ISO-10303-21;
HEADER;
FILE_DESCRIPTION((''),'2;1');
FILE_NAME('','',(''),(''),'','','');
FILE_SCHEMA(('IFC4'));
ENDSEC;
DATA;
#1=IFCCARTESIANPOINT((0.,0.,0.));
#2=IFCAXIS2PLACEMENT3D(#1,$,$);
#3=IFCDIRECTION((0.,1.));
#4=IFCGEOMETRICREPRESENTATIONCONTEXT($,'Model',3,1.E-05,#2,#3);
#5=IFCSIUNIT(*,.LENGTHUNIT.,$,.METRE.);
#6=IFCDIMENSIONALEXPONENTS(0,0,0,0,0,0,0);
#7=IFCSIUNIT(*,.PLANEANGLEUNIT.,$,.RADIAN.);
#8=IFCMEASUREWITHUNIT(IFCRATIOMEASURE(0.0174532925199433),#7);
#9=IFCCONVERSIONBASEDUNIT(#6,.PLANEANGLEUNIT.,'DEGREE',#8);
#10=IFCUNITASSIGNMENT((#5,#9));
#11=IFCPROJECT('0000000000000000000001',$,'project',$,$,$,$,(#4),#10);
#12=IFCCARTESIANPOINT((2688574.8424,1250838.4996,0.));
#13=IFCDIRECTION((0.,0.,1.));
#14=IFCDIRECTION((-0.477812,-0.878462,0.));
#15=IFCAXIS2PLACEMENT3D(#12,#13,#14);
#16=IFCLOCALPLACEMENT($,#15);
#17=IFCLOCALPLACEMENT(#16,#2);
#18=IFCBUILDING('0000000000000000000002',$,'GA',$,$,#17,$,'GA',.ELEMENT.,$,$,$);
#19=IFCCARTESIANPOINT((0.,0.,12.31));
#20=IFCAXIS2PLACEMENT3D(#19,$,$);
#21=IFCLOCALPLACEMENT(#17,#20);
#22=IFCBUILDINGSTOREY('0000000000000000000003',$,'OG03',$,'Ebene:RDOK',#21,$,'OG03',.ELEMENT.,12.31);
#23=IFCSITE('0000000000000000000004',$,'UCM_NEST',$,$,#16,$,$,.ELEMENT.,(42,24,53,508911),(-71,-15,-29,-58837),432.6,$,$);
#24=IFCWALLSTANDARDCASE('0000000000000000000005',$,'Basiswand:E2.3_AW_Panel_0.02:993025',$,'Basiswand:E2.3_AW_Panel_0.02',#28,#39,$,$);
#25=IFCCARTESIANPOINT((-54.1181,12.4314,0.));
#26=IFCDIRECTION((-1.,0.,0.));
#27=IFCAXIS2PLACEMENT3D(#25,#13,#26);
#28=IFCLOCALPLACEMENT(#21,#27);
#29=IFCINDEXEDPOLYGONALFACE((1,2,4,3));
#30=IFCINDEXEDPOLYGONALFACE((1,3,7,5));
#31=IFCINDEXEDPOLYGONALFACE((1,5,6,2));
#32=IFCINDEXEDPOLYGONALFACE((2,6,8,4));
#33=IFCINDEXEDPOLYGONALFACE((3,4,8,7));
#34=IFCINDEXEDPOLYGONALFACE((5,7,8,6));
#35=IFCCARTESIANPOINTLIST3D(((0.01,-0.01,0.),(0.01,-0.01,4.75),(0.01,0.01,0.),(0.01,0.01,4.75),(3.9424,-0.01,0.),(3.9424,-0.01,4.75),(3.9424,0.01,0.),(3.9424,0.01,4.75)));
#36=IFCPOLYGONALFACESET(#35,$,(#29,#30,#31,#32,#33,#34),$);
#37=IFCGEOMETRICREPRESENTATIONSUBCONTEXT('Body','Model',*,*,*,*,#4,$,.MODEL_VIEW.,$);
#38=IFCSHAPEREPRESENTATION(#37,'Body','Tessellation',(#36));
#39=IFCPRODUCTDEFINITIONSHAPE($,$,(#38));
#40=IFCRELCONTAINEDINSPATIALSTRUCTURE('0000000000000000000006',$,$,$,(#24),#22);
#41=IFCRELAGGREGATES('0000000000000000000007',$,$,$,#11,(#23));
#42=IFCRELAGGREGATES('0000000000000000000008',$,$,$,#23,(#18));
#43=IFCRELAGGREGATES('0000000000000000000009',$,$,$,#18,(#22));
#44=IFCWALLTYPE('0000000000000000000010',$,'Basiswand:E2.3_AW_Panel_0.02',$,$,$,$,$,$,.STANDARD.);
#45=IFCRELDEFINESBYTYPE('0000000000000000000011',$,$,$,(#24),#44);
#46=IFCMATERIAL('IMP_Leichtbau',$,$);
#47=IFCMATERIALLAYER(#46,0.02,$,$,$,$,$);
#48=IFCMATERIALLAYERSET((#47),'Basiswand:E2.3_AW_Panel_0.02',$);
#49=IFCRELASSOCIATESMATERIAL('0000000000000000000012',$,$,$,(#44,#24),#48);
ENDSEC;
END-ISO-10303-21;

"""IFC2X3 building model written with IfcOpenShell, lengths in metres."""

from ifc_helpers import new_model, entity, si_unit, converted_unit, direction, frame, frame_2d, origin, place, context, subcontext, project, spatial, rectangle, extrude, material, layer, layer_set, layer_usage, type_object, element, save


model = new_model("IFC2X3")

# Units and contexts
model_context = context("Model", 3, precision=1e-05, world=origin(), true_north=direction((0.0, 1.0)))
body_context = subcontext(model_context, "Body", "Model", "MODEL_VIEW")
ifc_project = project(units=[si_unit("LENGTHUNIT", "METRE"), converted_unit("PLANEANGLEUNIT", "DEGREE", entity("IfcRatioMeasure", 0.0174532925199433), si_unit("PLANEANGLEUNIT", "RADIAN"), dimensions=[0, 0, 0, 0, 0, 0, 0])], contexts=[model_context])

# Site, building, storey
site_placement = place(None, frame((2688574.8424, 1250838.4996, 0.0), z_axis=(0.0, 0.0, 1.0), x_axis=(-0.477812, -0.878462, 0.0)))
site = spatial("IfcSite", under=ifc_project, at=site_placement, Name="UCM_NEST", CompositionType="ELEMENT", RefLatitude=(42, 24, 53, 508911), RefLongitude=(-71, -15, -29, -58837), RefElevation=432.6)
building_placement = place(site_placement, origin())
building = spatial("IfcBuilding", under=site, at=building_placement, Name="GA", LongName="GA", CompositionType="ELEMENT")
storey_placement = place(building_placement, frame((0.0, 0.0, 12.31)))
storey = spatial("IfcBuildingStorey", under=building, at=storey_placement, Name="OG03", ObjectType="Ebene:RDOK", LongName="OG03", CompositionType="ELEMENT", Elevation=12.31)

# Wall
ifc_material_1 = material(Name="IMP_Leichtbau")
ifc_layer_1 = layer(ifc_material_1, 0.02)
ifc_layer_set_1 = layer_set([ifc_layer_1], Name="Basiswand:E2.3_AW_Panel_0.02")
wall_type_1 = type_object("IfcWallType", Name="Basiswand:E2.3_AW_Panel_0.02", PredefinedType="STANDARD", material=ifc_layer_set_1)
ifc_layer_usage_1 = layer_usage(ifc_layer_set_1, "AXIS2", "NEGATIVE", 0.01)
wall_1_placement = place(storey_placement, frame((-54.1181, 12.4314, 0.0), z_axis=(0.0, 0.0, 1.0), x_axis=(-1.0, 0.0, 0.0)))
element("IfcWallStandardCase", 1, at=wall_1_placement, inside=storey, type_object=wall_type_1, material=ifc_layer_usage_1, Name="Basiswand:E2.3_AW_Panel_0.02:993025", ObjectType="Basiswand:E2.3_AW_Panel_0.02", context=body_context, shape_type="SweptSolid", body=[
    extrude(rectangle(XDim=3.9324, YDim=0.02, at=frame_2d((1.9762, 0.0), x_axis=(-1.0, 0.0))), origin(), (0.0, 0.0, 1.0), 4.75),
])

save(model, "model.ifc")
